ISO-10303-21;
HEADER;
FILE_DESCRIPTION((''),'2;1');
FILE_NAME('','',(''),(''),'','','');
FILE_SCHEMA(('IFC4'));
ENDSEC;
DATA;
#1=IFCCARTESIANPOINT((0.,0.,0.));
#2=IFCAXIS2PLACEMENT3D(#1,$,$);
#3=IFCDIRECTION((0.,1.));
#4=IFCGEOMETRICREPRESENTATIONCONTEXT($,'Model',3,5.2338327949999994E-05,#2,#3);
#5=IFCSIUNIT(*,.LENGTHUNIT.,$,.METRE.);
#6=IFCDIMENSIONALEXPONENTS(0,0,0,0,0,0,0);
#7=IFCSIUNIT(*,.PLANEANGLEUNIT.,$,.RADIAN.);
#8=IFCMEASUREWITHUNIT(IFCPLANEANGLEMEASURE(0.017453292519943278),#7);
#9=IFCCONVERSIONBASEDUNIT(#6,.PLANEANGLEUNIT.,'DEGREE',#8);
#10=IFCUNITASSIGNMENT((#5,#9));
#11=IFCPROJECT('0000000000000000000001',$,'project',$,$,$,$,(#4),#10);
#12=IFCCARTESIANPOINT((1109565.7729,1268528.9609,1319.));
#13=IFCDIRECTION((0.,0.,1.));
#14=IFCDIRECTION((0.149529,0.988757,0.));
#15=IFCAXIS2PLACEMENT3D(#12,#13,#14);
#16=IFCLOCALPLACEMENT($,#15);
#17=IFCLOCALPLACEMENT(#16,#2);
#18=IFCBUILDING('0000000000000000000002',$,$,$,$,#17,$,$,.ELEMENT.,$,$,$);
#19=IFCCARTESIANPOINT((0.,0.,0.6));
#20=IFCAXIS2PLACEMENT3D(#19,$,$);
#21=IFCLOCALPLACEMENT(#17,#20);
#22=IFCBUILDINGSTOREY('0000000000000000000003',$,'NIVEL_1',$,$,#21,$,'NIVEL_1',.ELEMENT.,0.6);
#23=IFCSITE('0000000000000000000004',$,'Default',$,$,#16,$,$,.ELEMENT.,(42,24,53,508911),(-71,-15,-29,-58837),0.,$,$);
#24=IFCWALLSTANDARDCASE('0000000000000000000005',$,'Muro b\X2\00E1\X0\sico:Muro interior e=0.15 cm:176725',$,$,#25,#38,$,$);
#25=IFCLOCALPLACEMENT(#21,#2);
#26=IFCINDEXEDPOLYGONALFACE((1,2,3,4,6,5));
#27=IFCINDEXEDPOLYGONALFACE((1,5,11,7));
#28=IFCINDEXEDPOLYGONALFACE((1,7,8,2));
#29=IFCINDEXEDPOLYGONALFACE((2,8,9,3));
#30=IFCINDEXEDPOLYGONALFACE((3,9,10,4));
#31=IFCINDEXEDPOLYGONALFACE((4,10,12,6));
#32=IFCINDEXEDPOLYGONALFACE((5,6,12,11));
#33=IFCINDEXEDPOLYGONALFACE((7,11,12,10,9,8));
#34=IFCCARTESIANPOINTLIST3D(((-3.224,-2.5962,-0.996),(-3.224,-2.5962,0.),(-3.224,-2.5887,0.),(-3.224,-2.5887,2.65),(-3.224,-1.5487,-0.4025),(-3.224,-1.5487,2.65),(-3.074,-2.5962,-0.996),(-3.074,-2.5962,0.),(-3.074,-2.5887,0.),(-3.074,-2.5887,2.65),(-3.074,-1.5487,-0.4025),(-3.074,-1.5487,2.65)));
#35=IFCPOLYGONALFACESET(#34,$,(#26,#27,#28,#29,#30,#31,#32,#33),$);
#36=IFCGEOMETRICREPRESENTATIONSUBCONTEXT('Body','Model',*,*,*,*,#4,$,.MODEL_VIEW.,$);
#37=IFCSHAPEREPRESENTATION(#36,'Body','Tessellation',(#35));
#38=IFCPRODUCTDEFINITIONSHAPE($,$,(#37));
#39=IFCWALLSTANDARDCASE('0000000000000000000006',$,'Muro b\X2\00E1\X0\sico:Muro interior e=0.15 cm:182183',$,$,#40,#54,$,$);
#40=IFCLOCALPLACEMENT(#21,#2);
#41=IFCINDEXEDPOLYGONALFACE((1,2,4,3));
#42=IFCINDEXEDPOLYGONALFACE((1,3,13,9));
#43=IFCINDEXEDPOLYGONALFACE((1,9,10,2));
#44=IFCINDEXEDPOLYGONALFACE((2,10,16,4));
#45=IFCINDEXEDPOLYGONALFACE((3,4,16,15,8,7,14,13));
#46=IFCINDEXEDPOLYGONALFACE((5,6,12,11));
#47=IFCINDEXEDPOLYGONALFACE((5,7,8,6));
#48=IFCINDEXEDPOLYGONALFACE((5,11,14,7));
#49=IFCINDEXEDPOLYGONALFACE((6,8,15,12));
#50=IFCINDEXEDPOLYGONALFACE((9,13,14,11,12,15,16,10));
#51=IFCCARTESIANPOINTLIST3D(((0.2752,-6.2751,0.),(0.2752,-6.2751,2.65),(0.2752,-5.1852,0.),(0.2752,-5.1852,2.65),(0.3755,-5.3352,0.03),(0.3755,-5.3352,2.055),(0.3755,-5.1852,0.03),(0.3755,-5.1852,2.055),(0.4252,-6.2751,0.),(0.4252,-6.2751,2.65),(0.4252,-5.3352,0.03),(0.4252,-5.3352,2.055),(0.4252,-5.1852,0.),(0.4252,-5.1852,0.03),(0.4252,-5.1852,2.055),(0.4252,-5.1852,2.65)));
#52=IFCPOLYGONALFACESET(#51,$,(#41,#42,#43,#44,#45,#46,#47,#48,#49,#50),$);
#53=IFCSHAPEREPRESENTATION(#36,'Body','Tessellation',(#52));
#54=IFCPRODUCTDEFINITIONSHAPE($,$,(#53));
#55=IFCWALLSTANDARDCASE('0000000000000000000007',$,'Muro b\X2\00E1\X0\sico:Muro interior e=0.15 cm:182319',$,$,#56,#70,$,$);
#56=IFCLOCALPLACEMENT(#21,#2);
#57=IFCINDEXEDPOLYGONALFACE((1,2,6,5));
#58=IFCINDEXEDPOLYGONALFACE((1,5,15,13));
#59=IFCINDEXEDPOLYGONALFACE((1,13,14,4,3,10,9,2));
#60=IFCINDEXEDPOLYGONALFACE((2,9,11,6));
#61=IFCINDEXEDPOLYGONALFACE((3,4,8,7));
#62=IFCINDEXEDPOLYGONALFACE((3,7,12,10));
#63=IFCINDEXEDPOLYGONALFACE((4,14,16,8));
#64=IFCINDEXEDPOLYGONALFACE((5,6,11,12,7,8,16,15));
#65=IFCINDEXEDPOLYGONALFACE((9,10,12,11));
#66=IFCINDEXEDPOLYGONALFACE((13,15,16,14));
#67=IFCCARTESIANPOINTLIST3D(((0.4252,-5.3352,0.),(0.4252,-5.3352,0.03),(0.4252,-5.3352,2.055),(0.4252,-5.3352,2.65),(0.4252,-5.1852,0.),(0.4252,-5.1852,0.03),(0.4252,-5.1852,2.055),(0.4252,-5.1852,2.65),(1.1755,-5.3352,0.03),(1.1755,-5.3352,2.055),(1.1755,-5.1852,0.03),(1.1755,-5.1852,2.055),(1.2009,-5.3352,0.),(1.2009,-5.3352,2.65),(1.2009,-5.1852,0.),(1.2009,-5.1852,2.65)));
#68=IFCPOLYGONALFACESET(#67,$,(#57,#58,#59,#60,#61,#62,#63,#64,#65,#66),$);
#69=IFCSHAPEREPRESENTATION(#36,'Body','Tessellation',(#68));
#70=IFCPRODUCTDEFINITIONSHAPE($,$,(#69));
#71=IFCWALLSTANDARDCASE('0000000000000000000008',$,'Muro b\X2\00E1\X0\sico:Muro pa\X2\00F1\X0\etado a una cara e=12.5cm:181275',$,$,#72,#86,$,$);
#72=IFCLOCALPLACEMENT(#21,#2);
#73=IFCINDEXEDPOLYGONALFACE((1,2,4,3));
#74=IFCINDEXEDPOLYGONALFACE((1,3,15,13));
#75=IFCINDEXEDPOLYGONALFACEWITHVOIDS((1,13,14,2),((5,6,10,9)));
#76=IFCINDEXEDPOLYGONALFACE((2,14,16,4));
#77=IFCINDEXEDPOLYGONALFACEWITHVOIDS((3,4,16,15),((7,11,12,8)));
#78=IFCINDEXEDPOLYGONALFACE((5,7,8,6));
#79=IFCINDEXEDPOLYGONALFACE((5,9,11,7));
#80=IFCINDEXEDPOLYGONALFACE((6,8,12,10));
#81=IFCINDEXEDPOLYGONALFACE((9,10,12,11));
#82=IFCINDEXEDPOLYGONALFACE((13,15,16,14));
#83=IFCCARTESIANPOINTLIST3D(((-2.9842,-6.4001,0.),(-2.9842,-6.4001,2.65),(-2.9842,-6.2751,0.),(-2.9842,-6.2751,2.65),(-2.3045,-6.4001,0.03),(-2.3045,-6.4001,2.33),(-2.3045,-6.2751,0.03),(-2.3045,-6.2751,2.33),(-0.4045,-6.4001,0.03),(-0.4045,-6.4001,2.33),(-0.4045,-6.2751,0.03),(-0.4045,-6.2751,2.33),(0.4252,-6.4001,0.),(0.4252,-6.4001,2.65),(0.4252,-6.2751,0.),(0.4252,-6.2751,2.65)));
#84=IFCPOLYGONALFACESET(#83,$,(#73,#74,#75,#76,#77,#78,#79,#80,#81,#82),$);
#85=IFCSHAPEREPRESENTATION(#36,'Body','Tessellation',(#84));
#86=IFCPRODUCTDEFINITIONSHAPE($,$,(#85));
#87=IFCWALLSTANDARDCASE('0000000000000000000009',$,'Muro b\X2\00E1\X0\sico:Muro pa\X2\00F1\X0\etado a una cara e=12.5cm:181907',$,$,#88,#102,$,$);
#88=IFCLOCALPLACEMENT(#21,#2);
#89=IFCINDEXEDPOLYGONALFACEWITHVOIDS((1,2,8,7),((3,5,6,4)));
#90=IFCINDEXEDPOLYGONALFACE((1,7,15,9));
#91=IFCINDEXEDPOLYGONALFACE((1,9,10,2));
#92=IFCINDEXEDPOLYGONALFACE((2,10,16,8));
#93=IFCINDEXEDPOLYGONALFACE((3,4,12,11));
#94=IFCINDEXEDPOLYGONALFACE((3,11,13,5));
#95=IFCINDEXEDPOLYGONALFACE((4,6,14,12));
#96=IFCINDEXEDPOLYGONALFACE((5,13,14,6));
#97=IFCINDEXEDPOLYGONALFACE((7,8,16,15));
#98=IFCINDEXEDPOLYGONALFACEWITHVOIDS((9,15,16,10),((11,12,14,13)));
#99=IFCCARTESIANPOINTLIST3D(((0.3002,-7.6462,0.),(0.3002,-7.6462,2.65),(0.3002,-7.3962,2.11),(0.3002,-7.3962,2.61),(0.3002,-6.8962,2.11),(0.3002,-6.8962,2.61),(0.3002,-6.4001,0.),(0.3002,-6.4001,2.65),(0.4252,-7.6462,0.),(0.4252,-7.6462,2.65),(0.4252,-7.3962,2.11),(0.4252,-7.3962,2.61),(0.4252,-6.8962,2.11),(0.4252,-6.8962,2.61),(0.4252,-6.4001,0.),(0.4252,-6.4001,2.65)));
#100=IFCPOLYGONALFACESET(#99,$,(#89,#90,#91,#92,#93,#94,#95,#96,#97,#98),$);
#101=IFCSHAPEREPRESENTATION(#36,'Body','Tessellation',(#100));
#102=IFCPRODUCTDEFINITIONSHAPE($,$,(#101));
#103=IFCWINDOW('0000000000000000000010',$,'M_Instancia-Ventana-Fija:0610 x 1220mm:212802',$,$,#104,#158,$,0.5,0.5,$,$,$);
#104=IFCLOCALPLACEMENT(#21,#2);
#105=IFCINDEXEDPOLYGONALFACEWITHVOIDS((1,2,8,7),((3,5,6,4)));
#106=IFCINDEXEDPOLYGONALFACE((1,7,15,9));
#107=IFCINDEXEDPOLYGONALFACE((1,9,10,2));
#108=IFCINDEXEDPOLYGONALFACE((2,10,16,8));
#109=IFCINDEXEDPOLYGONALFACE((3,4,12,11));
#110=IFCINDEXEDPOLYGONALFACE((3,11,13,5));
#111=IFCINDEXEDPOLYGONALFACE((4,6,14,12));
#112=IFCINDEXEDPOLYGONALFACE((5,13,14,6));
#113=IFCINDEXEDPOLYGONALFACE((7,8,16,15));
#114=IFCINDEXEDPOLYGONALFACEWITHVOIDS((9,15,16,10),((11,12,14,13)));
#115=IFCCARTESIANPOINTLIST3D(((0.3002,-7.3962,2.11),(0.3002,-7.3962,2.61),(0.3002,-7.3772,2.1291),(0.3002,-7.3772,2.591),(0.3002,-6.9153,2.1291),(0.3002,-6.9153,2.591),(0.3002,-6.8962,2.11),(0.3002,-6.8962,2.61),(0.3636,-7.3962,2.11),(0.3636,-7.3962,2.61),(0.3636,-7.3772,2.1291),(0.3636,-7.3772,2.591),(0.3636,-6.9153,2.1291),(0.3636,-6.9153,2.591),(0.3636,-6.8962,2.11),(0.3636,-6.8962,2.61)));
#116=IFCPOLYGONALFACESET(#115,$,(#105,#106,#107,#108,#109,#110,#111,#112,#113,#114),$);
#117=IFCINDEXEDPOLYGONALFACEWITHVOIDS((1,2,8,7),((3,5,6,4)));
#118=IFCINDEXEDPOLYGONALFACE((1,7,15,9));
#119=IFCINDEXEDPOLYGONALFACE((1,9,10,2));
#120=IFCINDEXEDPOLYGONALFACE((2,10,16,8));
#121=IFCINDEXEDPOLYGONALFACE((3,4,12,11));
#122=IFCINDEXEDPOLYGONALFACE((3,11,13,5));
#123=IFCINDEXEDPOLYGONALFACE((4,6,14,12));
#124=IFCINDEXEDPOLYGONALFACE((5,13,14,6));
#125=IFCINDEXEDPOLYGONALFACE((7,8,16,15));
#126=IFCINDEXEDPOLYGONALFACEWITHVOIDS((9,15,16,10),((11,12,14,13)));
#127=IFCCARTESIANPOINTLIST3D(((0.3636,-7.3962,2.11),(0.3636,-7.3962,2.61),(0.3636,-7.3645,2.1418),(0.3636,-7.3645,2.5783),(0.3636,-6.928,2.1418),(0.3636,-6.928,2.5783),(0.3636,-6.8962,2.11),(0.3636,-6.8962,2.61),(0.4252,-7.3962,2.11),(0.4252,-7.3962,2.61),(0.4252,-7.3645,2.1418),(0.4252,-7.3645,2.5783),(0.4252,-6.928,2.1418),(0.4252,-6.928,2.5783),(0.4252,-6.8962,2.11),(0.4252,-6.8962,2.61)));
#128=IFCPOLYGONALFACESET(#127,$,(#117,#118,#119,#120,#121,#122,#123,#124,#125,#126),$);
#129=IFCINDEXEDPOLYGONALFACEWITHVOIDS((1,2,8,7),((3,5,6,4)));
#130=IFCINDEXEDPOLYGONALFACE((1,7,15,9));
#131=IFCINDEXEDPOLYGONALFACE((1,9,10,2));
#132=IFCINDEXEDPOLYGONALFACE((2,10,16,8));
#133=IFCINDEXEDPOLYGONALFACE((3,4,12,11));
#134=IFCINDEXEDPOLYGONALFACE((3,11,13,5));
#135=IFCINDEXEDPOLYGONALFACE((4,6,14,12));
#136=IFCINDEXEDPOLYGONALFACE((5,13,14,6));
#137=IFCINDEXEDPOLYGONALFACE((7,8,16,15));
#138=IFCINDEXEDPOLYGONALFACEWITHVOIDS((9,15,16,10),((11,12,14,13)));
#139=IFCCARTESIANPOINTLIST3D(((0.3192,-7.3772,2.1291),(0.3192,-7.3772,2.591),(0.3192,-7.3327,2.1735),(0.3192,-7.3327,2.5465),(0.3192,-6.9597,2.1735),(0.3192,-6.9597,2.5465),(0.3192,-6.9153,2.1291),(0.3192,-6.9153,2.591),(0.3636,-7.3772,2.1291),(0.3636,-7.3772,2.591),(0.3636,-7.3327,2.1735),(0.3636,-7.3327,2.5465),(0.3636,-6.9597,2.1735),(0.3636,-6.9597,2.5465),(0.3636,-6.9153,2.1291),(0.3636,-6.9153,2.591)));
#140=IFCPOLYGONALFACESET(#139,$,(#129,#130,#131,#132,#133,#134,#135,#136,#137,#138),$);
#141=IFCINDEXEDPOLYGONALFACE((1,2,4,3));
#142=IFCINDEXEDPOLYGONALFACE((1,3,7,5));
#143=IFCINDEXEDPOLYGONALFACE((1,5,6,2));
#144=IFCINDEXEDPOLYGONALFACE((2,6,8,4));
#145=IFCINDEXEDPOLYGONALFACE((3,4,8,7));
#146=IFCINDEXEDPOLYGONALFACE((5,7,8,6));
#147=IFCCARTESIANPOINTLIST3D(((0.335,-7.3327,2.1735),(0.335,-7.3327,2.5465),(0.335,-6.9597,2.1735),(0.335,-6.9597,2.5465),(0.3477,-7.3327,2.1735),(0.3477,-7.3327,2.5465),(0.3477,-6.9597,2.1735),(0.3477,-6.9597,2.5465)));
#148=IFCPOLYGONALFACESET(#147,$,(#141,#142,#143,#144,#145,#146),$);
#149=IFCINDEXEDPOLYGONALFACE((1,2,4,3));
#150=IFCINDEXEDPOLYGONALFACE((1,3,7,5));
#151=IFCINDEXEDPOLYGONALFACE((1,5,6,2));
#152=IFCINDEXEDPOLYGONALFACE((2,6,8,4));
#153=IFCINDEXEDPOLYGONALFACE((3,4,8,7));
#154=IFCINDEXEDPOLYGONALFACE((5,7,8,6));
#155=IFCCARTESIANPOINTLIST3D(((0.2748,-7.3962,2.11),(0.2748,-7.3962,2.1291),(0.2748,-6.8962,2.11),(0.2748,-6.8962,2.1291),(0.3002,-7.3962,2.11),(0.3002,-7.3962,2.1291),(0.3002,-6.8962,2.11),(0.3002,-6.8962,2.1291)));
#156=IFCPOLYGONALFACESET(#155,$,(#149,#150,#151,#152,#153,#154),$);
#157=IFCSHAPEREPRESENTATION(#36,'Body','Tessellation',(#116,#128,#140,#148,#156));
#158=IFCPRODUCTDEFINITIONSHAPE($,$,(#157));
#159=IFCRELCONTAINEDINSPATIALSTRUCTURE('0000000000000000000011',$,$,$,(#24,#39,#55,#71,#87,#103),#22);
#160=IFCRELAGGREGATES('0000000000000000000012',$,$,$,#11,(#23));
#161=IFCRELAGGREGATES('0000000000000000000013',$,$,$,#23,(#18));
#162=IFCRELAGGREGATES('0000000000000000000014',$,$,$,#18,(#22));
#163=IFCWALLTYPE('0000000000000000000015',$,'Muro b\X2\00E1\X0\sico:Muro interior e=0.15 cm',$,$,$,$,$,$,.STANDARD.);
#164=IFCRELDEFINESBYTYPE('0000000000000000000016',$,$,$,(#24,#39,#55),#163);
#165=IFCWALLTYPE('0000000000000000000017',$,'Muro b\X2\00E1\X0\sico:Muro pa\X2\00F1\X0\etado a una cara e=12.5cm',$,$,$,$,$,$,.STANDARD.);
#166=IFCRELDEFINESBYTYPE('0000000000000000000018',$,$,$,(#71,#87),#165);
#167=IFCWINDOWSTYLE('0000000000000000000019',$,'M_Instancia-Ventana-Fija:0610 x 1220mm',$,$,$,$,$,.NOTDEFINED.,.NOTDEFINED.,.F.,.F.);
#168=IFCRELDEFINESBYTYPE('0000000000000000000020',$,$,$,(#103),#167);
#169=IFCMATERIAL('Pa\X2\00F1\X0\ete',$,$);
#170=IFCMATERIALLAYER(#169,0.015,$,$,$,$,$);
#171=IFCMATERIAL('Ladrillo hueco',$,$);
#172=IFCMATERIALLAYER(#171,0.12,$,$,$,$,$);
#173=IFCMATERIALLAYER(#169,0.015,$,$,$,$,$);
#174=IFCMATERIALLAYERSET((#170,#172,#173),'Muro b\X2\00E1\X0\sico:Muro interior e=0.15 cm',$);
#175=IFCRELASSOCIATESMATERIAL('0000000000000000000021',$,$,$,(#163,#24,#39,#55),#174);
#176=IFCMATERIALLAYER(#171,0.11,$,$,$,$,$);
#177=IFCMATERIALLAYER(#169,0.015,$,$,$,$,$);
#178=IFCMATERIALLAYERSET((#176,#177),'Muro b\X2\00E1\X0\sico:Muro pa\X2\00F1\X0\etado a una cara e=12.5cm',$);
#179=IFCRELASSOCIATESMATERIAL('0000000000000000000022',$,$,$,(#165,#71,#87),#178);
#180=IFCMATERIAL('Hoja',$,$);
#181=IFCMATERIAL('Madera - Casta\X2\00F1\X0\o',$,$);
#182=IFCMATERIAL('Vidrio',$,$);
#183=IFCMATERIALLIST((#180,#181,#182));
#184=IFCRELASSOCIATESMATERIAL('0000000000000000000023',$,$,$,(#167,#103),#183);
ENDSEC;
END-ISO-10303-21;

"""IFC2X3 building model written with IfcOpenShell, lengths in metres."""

from ifc_helpers import new_model, entity, si_unit, converted_unit, direction, frame, frame_2d, origin, origin_2d_with_axis, place, context, subcontext, project, spatial, polyline, rectangle, outline, extrude, clip, halfspace, source, transform, mapped, material, material_list, layer, layer_set, layer_usage, type_object, type_shapes, element, fill, save


model = new_model("IFC2X3")

# Units and contexts
model_context = context("Model", 3, precision=5.2338327949999994e-05, world=origin(), true_north=direction((0.0, 1.0)))
body_context = subcontext(model_context, "Body", "Model", "MODEL_VIEW")
ifc_project = project(units=[si_unit("LENGTHUNIT", "METRE"), converted_unit("PLANEANGLEUNIT", "DEGREE", entity("IfcPlaneAngleMeasure", 0.017453292519943278), si_unit("PLANEANGLEUNIT", "RADIAN"), dimensions=[0, 0, 0, 0, 0, 0, 0])], contexts=[model_context])

# Site, building, storey
site_placement = place(None, frame((1109565.7729, 1268528.9609, 1319.0), z_axis=(0.0, 0.0, 1.0), x_axis=(0.149529, 0.988757, 0.0)))
site = spatial("IfcSite", under=ifc_project, at=site_placement, Name="Default", CompositionType="ELEMENT", RefLatitude=(42, 24, 53, 508911), RefLongitude=(-71, -15, -29, -58837), RefElevation=0.0)
building_placement = place(site_placement, origin())
building = spatial("IfcBuilding", under=site, at=building_placement, CompositionType="ELEMENT")
storey_placement = place(building_placement, frame((0.0, 0.0, 0.6)))
storey = spatial("IfcBuildingStorey", under=building, at=storey_placement, Name="NIVEL_1", LongName="NIVEL_1", CompositionType="ELEMENT", Elevation=0.6)

# Walls, openings
ifc_material_1 = material(Name="Pañete")
ifc_layer_1 = layer(ifc_material_1, 0.015)
ifc_material_2 = material(Name="Ladrillo hueco")
ifc_layer_2 = layer(ifc_material_2, 0.12)
ifc_layer_3 = layer(ifc_material_1, 0.015)
ifc_layer_set_1 = layer_set([ifc_layer_1, ifc_layer_2, ifc_layer_3], Name="Muro básico:Muro interior e=0.15 cm")
ifc_layer_usage_1 = layer_usage(ifc_layer_set_1, "AXIS2", "POSITIVE", -0.075)
wall_type_1 = type_object("IfcWallType", Name="Muro básico:Muro interior e=0.15 cm", PredefinedType="STANDARD", material=ifc_layer_set_1)
wall_1_placement = place(storey_placement, frame((-3.149, -2.5962, -0.996), z_axis=(0.0, 0.0, 1.0), x_axis=(0.0, 1.0, 0.0)))
wall_1 = element("IfcWallStandardCase", 1, at=wall_1_placement, inside=storey, type_object=wall_type_1, material=ifc_layer_usage_1, Name="Muro básico:Muro interior e=0.15 cm:176725", context=body_context, shape_type="Clipping", body=[
    clip(extrude(rectangle(XDim=1.0475, YDim=0.15, at=frame_2d((0.5237, 0.0), x_axis=(-1.0, 0.0))), origin(), (0.0, 0.0, 1.0), 3.646), halfspace(frame((1.0475, -0.075, 0.5936), z_axis=(0.493013, 0.0, -0.870022), x_axis=(0.0, 1.0, 0.0)), False)),
])
opening_1_placement = place(wall_1_placement, origin())
element("IfcOpeningElement", 2, at=opening_1_placement, cuts=wall_1, ObjectType="Opening", context=body_context, shape_type="SweptSolid", body=[
    extrude(rectangle(XDim=2.65, YDim=0.0075, at=frame_2d((0.0, 0.0), x_axis=(0.0, 1.0))), frame((0.0037, 0.075, 2.321), z_axis=(0.0, -1.0, 0.0), x_axis=(1.0, 0.0, 0.0)), (0.0, 0.0, 1.0), 0.15),
])
ifc_layer_usage_2 = layer_usage(ifc_layer_set_1, "AXIS2", "NEGATIVE", 0.075)
wall_2_placement = place(storey_placement, frame((0.3502, -6.2751, 0.0), z_axis=(0.0, 0.0, 1.0), x_axis=(0.0, 1.0, 0.0)))
wall_2 = element("IfcWallStandardCase", 3, at=wall_2_placement, inside=storey, type_object=wall_type_1, material=ifc_layer_usage_2, Name="Muro básico:Muro interior e=0.15 cm:182183", context=body_context, shape_type="SweptSolid", body=[
    extrude(rectangle(XDim=1.0899, YDim=0.15, at=frame_2d((0.545, 0.0), x_axis=(-1.0, 0.0))), origin(), (0.0, 0.0, 1.0), 2.65),
])
opening_2_placement = place(wall_2_placement, origin())
element("IfcOpeningElement", 4, at=opening_2_placement, cuts=wall_2, ObjectType="Opening", context=body_context, shape_type="SweptSolid", body=[
    extrude(rectangle(XDim=2.025, YDim=0.15, at=frame_2d((0.0, 0.0), x_axis=(0.0, 1.0))), frame((1.0149, -0.8254, 1.0425), z_axis=(0.0, 1.0, 0.0), x_axis=(-1.0, 0.0, 0.0)), (0.0, 0.0, 1.0), 0.8),
])
ifc_layer_usage_3 = layer_usage(ifc_layer_set_1, "AXIS2", "NEGATIVE", 0.075)
wall_3_placement = place(storey_placement, frame((0.4252, -5.2602, 0.0)))
wall_3 = element("IfcWallStandardCase", 5, at=wall_3_placement, inside=storey, type_object=wall_type_1, material=ifc_layer_usage_3, Name="Muro básico:Muro interior e=0.15 cm:182319", context=body_context, shape_type="SweptSolid", body=[
    extrude(rectangle(XDim=0.7757, YDim=0.15, at=frame_2d((0.3879, 0.0), x_axis=(-1.0, 0.0))), origin(), (0.0, 0.0, 1.0), 2.65),
])
opening_3_placement = place(wall_3_placement, frame((0.7504, 0.075, 0.03)))
element("IfcOpeningElement", 6, at=opening_3_placement, cuts=wall_3, ObjectType="Opening", context=body_context, shape_type="SweptSolid", body=[
    extrude(rectangle(XDim=2.025, YDim=0.8, at=frame_2d((1.0125, 0.4), x_axis=(1.0, 0.0))), frame((0.0, 0.0, 0.0), z_axis=(0.0, -1.0, 0.0), x_axis=(0.0, 0.0, 1.0)), (0.0, 0.0, 1.0), 0.15),
])
ifc_layer_4 = layer(ifc_material_2, 0.11)
ifc_layer_5 = layer(ifc_material_1, 0.015)
ifc_layer_set_2 = layer_set([ifc_layer_4, ifc_layer_5], Name="Muro básico:Muro pañetado a una cara e=12.5cm")
ifc_layer_usage_4 = layer_usage(ifc_layer_set_2, "AXIS2", "POSITIVE", -0.0625)
wall_type_2 = type_object("IfcWallType", Name="Muro básico:Muro pañetado a una cara e=12.5cm", PredefinedType="STANDARD", material=ifc_layer_set_2)
wall_4_placement = place(storey_placement, frame((-2.9842, -6.3376, 0.0)))
wall_4 = element("IfcWallStandardCase", 7, at=wall_4_placement, inside=storey, type_object=wall_type_2, material=ifc_layer_usage_4, Name="Muro básico:Muro pañetado a una cara e=12.5cm:181275", context=body_context, shape_type="SweptSolid", body=[
    extrude(rectangle(XDim=3.4094, YDim=0.125, at=frame_2d((1.7047, 0.0), x_axis=(-1.0, 0.0))), origin(), (0.0, 0.0, 1.0), 2.65),
])
opening_4_placement = place(wall_4_placement, frame((0.6797, -0.0625, 0.03)))
element("IfcOpeningElement", 8, at=opening_4_placement, cuts=wall_4, ObjectType="Opening", context=body_context, shape_type="SweptSolid", body=[
    extrude(rectangle(XDim=2.3, YDim=1.9, at=frame_2d((1.15, 0.95), x_axis=(1.0, 0.0))), frame((0.0, 0.0, 0.0), z_axis=(0.0, 1.0, 0.0), x_axis=(0.0, 0.0, 1.0)), (0.0, 0.0, 1.0), 0.125),
])

# Wall, opening, window
ifc_layer_usage_5 = layer_usage(ifc_layer_set_2, "AXIS2", "POSITIVE", -0.0625)
wall_5_placement = place(storey_placement, frame((0.3627, -6.4001, 0.0), z_axis=(0.0, 0.0, 1.0), x_axis=(0.0, -1.0, 0.0)))
wall_5 = element("IfcWallStandardCase", 9, at=wall_5_placement, inside=storey, type_object=wall_type_2, material=ifc_layer_usage_5, Name="Muro básico:Muro pañetado a una cara e=12.5cm:181907", context=body_context, shape_type="SweptSolid", body=[
    extrude(rectangle(XDim=1.2461, YDim=0.125, at=frame_2d((0.623, 0.0), x_axis=(-1.0, 0.0))), origin(), (0.0, 0.0, 1.0), 2.65),
])
opening_5_placement = place(wall_5_placement, frame((0.9961, 0.0625, 2.11)))
opening_5 = element("IfcOpeningElement", 10, at=opening_5_placement, cuts=wall_5, ObjectType="Opening", context=body_context, shape_type="SweptSolid", body=[
    extrude(rectangle(XDim=0.5, YDim=0.5, at=frame_2d((0.25, 0.25), x_axis=(-1.0, 0.0))), frame((0.0, 0.0, 0.0), z_axis=(0.0, -1.0, 0.0), x_axis=(0.0, 0.0, 1.0)), (0.0, 0.0, 1.0), 0.125),
])
ifc_material_3 = material(Name="Hoja")
ifc_material_4 = material(Name="Madera - Castaño")
ifc_material_5 = material(Name="Vidrio")
ifc_material_list = material_list([ifc_material_3, ifc_material_4, ifc_material_5])
window_style = type_object("IfcWindowStyle", Name="M_Instancia-Ventana-Fija:0610 x 1220mm", ConstructionType="NOTDEFINED", OperationType="NOTDEFINED", ParameterTakesPrecedence=False, Sizeable=False, material=ifc_material_list)
shared_shape = source(origin(), body_context, "Body", "SweptSolid", [
    extrude(outline(polyline([(-0.25, -0.25), (0.25, -0.25), (0.25, 0.25), (-0.25, 0.25), (-0.25, -0.25)]), holes=[polyline([(-0.2309, -0.2309), (-0.2309, 0.231), (0.231, 0.231), (0.231, -0.2309), (-0.2309, -0.2309)])]), frame((0.25, 0.0616, 0.25), z_axis=(0.0, 1.0, 0.0), x_axis=(0.0, 0.0, -1.0)), (0.0, 0.0, 1.0), 0.0635),
    extrude(outline(polyline([(-0.25, -0.25), (0.25, -0.25), (0.25, 0.25), (-0.25, 0.25), (-0.25, -0.25)]), holes=[polyline([(-0.2183, -0.2182), (-0.2183, 0.2183), (0.2182, 0.2183), (0.2182, -0.2182), (-0.2183, -0.2182)])]), frame((0.25, 0.0, 0.25), z_axis=(0.0, 1.0, 0.0), x_axis=(1.0, 0.0, 0.0)), (0.0, 0.0, 1.0), 0.0616),
    extrude(outline(polyline([(-0.2309, -0.231), (0.2309, -0.231), (0.2309, 0.231), (-0.2309, 0.231), (-0.2309, -0.231)]), holes=[polyline([(-0.1865, -0.1865), (-0.1865, 0.1865), (0.1865, 0.1865), (0.1865, -0.1865), (-0.1865, -0.1865)])]), frame((0.25, 0.0616, 0.25), z_axis=(0.0, 1.0, 0.0), x_axis=(1.0, 0.0, 0.0)), (0.0, 0.0, 1.0), 0.0444),
    extrude(rectangle(XDim=0.0127, YDim=0.373, at=origin_2d_with_axis()), frame((0.25, 0.0838, 0.0635), z_axis=(0.0, 0.0, 1.0), x_axis=(0.0, 1.0, 0.0)), (0.0, 0.0, 1.0), 0.373),
    extrude(rectangle(XDim=0.0254, YDim=0.5, at=origin_2d_with_axis()), frame((0.25, 0.1377, 0.0), z_axis=(0.0, 0.0, 1.0), x_axis=(0.0, -1.0, 0.0)), (0.0, 0.0, 1.0), 0.019),
])
type_shapes(window_style, [shared_shape])
window_placement = place(opening_5_placement, frame((0.0, 0.0, 0.0), z_axis=(0.0, 0.0, 1.0), x_axis=(-1.0, 0.0, 0.0)))
window = element("IfcWindow", 11, at=window_placement, inside=storey, type_object=window_style, material=ifc_material_list, Name="M_Instancia-Ventana-Fija:0610 x 1220mm:212802", OverallHeight=0.5, OverallWidth=0.5, context=body_context, shape_type="MappedRepresentation", body=[
    mapped(shared_shape, transform((0.0, 0.0, 0.0), scale=1.0)),
])
fill(opening_5, window)

save(model, "model.ifc")
